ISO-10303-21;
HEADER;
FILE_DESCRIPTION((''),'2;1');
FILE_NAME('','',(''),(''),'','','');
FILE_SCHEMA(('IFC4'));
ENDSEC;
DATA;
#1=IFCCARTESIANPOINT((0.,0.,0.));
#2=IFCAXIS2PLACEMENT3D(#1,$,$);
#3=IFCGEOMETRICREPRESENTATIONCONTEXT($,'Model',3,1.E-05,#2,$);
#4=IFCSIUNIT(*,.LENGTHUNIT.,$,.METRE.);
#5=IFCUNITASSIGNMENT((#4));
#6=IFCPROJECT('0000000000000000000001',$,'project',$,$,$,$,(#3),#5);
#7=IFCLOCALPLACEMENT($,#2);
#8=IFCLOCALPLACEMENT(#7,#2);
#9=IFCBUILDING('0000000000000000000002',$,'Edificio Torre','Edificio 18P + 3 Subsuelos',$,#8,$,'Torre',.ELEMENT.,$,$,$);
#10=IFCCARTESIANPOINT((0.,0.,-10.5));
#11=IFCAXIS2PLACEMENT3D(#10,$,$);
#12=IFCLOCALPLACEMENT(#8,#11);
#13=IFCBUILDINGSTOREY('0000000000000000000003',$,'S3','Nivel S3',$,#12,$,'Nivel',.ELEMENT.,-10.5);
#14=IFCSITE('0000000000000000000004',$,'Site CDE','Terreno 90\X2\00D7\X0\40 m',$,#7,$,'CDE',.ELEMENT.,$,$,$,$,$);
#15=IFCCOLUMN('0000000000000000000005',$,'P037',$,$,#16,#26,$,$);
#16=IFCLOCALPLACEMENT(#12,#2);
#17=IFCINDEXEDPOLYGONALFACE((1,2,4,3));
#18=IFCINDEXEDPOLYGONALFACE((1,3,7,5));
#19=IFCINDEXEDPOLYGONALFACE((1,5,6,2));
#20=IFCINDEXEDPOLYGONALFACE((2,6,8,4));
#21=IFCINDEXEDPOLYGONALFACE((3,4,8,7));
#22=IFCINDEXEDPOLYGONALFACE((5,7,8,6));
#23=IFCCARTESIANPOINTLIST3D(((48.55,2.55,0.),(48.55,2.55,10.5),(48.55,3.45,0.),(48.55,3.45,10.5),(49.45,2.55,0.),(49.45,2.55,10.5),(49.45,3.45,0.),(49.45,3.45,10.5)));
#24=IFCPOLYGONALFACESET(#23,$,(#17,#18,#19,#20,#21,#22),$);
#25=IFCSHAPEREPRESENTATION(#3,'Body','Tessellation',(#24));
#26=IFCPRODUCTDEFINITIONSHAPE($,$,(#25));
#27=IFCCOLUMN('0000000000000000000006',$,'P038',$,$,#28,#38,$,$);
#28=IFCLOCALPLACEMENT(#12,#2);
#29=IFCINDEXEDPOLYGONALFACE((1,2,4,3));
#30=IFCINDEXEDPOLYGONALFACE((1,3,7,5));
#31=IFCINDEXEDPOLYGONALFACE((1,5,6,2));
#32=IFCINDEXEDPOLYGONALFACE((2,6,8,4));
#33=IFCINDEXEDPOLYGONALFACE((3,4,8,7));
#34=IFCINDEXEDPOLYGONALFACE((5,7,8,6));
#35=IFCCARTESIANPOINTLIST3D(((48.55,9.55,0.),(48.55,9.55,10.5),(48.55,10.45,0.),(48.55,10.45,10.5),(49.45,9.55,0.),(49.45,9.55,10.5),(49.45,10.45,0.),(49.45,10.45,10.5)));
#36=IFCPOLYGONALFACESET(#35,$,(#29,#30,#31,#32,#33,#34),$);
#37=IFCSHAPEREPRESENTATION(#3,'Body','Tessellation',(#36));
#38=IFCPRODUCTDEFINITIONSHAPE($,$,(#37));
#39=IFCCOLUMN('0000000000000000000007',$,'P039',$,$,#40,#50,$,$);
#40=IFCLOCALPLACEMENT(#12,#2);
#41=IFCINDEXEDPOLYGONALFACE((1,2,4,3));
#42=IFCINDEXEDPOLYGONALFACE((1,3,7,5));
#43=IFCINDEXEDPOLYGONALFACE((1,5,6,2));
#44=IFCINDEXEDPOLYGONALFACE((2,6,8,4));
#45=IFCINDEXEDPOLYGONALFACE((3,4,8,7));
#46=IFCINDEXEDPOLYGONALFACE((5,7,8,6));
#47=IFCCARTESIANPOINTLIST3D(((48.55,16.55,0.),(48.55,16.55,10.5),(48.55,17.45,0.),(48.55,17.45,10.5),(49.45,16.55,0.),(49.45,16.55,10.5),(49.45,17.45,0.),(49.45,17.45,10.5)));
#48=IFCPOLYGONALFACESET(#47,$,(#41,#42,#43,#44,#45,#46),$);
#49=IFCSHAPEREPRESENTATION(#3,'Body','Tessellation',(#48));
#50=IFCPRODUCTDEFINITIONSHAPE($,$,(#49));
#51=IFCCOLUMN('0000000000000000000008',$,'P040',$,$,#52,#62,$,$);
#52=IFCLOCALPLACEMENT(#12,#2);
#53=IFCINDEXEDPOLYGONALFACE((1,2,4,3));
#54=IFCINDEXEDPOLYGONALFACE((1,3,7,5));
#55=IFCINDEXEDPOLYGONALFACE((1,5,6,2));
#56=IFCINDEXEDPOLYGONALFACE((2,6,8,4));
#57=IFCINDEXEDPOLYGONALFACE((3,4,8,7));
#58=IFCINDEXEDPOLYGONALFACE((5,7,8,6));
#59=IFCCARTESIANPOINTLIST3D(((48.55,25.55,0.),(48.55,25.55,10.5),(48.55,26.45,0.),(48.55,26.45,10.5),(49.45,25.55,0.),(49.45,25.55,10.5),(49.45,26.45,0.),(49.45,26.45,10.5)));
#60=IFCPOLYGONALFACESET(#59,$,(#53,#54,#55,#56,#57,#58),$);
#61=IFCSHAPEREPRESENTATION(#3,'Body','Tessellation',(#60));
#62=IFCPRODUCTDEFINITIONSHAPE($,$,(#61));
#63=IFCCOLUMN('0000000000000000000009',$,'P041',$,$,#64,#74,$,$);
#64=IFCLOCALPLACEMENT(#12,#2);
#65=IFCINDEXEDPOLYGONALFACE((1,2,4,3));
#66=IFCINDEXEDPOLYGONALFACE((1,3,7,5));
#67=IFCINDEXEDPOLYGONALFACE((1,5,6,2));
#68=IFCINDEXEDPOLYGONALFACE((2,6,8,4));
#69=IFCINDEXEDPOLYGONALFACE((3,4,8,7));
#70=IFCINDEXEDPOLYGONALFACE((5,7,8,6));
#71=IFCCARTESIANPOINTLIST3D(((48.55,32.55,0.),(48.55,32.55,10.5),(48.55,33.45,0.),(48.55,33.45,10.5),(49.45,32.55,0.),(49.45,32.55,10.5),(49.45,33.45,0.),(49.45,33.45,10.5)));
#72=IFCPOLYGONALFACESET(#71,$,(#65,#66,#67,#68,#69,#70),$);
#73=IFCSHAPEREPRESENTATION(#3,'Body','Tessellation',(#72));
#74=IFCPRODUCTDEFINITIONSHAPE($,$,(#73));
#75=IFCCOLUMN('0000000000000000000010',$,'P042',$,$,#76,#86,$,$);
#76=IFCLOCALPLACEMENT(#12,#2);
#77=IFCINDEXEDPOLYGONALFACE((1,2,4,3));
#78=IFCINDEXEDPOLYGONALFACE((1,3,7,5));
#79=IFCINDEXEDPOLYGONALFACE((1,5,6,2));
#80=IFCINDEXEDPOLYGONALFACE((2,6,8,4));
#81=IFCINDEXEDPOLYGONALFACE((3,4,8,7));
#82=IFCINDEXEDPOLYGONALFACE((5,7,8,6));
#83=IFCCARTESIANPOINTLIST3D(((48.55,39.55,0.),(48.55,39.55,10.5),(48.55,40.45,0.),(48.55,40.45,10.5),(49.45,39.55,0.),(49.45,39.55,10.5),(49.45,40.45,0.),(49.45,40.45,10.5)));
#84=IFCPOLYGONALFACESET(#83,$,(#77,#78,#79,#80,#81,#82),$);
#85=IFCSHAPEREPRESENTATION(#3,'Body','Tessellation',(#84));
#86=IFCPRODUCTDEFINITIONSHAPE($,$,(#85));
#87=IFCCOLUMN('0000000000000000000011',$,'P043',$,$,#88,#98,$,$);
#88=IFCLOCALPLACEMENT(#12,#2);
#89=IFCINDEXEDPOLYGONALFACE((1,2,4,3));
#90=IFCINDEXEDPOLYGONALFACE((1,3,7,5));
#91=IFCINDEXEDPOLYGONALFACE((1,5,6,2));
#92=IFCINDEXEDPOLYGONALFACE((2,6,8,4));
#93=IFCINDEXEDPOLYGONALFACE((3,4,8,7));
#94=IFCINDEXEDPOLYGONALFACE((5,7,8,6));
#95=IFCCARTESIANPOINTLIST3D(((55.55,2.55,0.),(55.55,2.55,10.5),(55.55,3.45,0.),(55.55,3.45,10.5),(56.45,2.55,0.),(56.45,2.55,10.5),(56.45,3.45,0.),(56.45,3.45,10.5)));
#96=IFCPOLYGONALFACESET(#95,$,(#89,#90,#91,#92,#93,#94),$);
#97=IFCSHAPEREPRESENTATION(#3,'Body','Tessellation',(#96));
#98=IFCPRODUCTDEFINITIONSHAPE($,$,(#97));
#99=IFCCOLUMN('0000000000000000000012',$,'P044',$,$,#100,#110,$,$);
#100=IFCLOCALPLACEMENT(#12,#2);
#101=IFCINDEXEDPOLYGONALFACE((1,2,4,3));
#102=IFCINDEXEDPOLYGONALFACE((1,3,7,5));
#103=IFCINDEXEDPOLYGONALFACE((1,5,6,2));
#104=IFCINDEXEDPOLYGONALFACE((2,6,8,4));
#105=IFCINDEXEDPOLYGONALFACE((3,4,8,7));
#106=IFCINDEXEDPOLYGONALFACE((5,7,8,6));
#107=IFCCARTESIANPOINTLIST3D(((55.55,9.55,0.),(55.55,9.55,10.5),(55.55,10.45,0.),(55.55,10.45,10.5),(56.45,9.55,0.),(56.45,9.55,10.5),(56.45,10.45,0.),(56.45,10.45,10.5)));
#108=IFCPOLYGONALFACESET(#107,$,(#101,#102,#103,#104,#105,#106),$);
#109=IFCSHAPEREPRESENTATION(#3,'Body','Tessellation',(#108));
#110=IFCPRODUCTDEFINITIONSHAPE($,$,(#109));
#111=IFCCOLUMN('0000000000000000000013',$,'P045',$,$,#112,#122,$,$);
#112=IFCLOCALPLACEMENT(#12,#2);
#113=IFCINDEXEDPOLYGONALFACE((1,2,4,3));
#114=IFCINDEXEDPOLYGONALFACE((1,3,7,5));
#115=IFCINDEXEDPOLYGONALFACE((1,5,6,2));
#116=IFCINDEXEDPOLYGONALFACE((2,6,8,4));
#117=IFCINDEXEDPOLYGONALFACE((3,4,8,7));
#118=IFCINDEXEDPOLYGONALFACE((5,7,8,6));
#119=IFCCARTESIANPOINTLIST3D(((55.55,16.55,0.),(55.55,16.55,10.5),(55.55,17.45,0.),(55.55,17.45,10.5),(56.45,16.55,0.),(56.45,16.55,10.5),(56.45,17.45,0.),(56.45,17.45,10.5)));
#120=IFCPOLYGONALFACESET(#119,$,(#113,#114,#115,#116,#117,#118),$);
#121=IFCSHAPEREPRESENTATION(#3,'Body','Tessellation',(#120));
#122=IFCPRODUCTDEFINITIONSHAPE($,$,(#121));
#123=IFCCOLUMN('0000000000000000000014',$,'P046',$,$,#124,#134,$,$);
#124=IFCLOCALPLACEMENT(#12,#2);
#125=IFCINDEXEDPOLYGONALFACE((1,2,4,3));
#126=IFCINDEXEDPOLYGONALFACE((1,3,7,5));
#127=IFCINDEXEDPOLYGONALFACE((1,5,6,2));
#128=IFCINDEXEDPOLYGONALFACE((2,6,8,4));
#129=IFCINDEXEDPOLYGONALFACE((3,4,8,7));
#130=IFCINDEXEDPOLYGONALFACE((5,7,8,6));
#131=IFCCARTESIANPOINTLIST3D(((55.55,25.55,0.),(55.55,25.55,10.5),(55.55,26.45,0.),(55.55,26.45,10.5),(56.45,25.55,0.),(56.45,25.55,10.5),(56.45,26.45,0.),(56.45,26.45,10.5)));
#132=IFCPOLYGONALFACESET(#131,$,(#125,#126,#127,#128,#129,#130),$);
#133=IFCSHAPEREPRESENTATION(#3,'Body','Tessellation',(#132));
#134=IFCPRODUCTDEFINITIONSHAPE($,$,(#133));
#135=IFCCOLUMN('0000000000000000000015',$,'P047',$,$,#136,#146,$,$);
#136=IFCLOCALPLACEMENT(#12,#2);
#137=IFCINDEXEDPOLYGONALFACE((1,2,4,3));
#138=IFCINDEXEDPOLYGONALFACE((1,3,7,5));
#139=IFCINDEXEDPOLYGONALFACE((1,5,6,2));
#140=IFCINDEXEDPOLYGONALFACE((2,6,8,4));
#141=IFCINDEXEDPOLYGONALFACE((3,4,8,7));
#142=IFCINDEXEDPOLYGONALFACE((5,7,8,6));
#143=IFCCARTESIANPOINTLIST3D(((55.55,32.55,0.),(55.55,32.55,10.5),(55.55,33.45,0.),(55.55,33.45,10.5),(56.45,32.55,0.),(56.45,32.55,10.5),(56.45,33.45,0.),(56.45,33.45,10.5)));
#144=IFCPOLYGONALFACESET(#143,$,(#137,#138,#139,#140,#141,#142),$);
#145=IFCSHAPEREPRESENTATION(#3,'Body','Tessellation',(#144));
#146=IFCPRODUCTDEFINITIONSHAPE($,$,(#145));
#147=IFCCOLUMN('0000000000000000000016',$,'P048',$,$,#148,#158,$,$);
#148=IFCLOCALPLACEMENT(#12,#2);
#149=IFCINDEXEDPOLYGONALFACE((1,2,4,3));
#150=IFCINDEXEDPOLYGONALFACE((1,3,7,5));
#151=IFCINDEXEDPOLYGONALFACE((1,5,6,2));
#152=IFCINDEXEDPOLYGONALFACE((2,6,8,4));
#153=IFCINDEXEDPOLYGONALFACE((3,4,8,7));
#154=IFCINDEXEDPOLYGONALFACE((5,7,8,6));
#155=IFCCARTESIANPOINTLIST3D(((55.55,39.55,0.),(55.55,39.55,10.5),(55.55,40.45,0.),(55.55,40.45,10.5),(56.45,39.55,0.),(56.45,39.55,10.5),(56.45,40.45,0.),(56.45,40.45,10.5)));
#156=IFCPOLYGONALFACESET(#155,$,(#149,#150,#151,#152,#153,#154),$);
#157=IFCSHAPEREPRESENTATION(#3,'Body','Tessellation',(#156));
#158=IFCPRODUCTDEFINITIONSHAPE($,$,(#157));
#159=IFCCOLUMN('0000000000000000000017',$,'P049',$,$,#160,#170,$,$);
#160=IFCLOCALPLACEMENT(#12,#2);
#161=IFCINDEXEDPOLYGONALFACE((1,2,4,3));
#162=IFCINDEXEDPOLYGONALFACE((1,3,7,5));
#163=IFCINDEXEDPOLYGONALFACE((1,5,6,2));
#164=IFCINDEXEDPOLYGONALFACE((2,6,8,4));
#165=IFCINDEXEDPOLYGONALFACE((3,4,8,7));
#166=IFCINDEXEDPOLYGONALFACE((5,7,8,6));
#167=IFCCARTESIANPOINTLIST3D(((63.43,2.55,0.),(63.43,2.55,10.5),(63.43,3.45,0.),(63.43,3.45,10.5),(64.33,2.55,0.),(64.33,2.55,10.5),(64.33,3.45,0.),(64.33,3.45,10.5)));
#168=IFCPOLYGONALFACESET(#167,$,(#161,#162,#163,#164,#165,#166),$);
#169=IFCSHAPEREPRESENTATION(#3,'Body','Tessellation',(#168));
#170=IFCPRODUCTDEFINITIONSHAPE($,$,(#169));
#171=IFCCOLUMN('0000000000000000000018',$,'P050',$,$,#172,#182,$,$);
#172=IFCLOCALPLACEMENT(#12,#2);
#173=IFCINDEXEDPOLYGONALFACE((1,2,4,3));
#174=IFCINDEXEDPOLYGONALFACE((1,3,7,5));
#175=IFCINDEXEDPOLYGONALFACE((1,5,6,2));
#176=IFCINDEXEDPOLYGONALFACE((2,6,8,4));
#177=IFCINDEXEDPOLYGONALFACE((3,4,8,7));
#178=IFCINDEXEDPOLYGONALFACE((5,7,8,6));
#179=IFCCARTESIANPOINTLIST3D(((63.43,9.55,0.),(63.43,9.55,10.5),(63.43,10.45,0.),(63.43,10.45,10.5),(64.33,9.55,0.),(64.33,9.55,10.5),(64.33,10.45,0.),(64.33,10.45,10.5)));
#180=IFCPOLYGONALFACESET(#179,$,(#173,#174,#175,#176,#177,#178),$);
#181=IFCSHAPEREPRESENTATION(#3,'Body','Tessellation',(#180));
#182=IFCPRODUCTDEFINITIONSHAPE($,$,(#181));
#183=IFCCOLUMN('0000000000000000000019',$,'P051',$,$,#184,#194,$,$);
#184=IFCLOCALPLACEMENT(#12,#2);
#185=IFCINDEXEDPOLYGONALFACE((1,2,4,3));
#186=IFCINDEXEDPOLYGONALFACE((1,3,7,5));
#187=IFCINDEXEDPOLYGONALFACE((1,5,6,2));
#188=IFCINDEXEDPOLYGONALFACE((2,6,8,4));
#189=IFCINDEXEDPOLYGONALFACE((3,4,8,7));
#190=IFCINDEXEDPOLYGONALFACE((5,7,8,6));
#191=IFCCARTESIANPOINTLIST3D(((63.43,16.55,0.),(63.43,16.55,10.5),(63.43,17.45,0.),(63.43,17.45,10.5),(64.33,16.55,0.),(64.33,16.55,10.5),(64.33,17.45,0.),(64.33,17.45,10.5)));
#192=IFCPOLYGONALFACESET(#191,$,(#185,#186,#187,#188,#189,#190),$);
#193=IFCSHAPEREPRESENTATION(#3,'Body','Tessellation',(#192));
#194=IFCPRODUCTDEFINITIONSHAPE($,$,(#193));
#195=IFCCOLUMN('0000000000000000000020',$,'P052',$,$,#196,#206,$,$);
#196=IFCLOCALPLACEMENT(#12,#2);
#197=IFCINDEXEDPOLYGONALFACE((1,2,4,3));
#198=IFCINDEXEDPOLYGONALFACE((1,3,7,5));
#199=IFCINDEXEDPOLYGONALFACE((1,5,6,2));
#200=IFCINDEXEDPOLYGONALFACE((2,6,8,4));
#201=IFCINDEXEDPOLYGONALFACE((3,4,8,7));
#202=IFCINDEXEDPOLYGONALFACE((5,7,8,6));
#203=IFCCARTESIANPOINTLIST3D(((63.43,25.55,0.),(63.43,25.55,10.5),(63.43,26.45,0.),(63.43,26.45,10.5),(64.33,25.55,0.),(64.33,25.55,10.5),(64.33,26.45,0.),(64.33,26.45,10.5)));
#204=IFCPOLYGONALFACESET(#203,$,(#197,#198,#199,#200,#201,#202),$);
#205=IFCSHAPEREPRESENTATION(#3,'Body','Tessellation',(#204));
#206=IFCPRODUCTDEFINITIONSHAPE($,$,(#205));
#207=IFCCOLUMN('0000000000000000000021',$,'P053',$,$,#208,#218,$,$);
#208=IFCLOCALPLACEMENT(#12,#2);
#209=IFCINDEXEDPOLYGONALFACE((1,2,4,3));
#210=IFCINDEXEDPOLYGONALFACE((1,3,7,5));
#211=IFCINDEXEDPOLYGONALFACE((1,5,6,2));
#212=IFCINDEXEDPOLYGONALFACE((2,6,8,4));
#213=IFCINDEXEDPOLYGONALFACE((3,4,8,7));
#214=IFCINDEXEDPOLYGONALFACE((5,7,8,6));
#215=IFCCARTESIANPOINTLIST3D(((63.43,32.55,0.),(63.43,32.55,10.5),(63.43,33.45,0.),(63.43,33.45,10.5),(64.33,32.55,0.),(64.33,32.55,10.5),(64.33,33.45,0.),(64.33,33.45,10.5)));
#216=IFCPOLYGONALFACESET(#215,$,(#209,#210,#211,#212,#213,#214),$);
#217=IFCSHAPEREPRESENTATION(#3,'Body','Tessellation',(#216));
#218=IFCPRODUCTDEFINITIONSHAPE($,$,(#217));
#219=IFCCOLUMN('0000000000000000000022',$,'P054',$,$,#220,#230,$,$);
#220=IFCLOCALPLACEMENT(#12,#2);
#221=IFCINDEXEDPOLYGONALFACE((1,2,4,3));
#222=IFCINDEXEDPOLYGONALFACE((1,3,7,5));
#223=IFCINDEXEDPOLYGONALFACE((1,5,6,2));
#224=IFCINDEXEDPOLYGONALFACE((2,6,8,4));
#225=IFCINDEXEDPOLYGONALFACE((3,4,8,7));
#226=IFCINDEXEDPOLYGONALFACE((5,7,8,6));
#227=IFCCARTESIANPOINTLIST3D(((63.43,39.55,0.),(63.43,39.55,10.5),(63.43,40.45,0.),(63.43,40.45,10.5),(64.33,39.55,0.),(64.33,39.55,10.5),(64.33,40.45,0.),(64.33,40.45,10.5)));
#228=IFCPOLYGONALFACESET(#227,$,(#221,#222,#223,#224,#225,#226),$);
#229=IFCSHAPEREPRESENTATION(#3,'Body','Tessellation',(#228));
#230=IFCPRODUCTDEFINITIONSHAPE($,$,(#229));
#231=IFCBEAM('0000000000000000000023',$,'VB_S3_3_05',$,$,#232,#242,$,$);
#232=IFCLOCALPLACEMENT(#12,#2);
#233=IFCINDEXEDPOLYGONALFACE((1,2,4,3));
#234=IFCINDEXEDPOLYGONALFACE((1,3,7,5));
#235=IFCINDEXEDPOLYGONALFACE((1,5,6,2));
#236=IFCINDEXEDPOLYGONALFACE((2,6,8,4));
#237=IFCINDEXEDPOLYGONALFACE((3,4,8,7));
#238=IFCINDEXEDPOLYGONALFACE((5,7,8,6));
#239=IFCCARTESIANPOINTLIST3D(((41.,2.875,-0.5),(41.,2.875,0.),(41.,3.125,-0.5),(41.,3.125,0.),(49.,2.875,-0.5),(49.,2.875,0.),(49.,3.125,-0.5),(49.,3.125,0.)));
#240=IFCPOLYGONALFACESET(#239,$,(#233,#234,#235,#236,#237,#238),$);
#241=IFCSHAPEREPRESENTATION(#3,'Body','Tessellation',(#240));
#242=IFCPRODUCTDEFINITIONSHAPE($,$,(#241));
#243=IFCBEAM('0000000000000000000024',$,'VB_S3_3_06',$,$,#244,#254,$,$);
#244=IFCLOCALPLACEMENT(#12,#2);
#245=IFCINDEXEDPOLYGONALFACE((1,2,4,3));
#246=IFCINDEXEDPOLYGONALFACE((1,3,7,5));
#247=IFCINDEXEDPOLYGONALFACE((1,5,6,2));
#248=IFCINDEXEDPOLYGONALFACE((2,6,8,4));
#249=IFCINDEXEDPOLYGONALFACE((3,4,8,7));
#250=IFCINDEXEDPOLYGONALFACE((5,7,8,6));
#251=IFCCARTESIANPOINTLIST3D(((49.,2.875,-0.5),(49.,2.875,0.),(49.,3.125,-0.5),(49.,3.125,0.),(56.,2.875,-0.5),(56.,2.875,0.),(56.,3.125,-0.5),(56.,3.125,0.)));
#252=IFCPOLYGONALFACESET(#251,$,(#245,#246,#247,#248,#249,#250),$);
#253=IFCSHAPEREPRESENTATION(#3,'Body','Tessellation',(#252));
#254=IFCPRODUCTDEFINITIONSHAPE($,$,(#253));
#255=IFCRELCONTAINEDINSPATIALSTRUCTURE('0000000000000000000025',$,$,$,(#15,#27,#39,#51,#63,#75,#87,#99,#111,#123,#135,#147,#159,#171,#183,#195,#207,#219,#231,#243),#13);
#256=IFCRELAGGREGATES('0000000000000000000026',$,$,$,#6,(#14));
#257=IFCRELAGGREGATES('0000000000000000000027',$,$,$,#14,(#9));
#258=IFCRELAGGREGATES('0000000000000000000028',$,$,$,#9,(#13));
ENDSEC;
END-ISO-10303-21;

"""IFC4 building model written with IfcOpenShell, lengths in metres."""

from ifc_helpers import new_model, si_unit, frame, origin, origin_2d, place, context, project, spatial, rectangle, extrude, element, save


model = new_model("IFC4")

# Units and contexts
model_context = context("Model", 3, precision=1e-05, world=origin())
ifc_project = project(units=[si_unit("LENGTHUNIT", "METRE")], contexts=[model_context])

# Site, building, storey
site_placement = place(None, origin())
site = spatial("IfcSite", under=ifc_project, at=site_placement, Name="Site CDE", Description="Terreno 90×40 m", LongName="CDE", CompositionType="ELEMENT")
building_placement = place(site_placement, origin())
building = spatial("IfcBuilding", under=site, at=building_placement, Name="Edificio Torre", Description="Edificio 18P + 3 Subsuelos", LongName="Torre", CompositionType="ELEMENT")
storey_placement = place(building_placement, frame((0.0, 0.0, -10.5)))
storey = spatial("IfcBuildingStorey", under=building, at=storey_placement, Name="S3", Description="Nivel S3", LongName="Nivel", CompositionType="ELEMENT", Elevation=-10.5)

# Columns
for number, where, name in (
    (1, (49.0, 3.0, 0.0), "P037"),
    (2, (49.0, 10.0, 0.0), "P038"),
    (3, (49.0, 17.0, 0.0), "P039"),
    (4, (49.0, 26.0, 0.0), "P040"),
    (5, (49.0, 33.0, 0.0), "P041"),
    (6, (49.0, 40.0, 0.0), "P042"),
    (7, (56.0, 3.0, 0.0), "P043"),
    (8, (56.0, 10.0, 0.0), "P044"),
    (9, (56.0, 17.0, 0.0), "P045"),
    (10, (56.0, 26.0, 0.0), "P046"),
    (11, (56.0, 33.0, 0.0), "P047"),
    (12, (56.0, 40.0, 0.0), "P048"),
    (13, (63.88, 3.0, 0.0), "P049"),
    (14, (63.88, 10.0, 0.0), "P050"),
    (15, (63.88, 17.0, 0.0), "P051"),
    (16, (63.88, 26.0, 0.0), "P052"),
    (17, (63.88, 33.0, 0.0), "P053"),
    (18, (63.88, 40.0, 0.0), "P054"),
):
    element("IfcColumn", number, at=place(storey_placement, frame(where)), inside=storey, Name=name, context=model_context, shape_type="SweptSolid", body=[
        extrude(rectangle(XDim=0.9, YDim=0.9, at=origin_2d()), origin(), (0.0, 0.0, 1.0), 10.5),
    ])

# Beams
beam_1_placement = place(storey_placement, frame((45.0, 3.0, -0.5)))
element("IfcBeam", 19, at=beam_1_placement, inside=storey, Name="VB_S3_3_05", context=model_context, shape_type="SweptSolid", body=[
    extrude(rectangle(XDim=8.0, YDim=0.25, at=origin_2d()), origin(), (0.0, 0.0, 1.0), 0.5),
])
beam_2_placement = place(storey_placement, frame((52.5, 3.0, -0.5)))
element("IfcBeam", 20, at=beam_2_placement, inside=storey, Name="VB_S3_3_06", context=model_context, shape_type="SweptSolid", body=[
    extrude(rectangle(XDim=7.0, YDim=0.25, at=origin_2d()), origin(), (0.0, 0.0, 1.0), 0.5),
])

save(model, "model.ifc")
